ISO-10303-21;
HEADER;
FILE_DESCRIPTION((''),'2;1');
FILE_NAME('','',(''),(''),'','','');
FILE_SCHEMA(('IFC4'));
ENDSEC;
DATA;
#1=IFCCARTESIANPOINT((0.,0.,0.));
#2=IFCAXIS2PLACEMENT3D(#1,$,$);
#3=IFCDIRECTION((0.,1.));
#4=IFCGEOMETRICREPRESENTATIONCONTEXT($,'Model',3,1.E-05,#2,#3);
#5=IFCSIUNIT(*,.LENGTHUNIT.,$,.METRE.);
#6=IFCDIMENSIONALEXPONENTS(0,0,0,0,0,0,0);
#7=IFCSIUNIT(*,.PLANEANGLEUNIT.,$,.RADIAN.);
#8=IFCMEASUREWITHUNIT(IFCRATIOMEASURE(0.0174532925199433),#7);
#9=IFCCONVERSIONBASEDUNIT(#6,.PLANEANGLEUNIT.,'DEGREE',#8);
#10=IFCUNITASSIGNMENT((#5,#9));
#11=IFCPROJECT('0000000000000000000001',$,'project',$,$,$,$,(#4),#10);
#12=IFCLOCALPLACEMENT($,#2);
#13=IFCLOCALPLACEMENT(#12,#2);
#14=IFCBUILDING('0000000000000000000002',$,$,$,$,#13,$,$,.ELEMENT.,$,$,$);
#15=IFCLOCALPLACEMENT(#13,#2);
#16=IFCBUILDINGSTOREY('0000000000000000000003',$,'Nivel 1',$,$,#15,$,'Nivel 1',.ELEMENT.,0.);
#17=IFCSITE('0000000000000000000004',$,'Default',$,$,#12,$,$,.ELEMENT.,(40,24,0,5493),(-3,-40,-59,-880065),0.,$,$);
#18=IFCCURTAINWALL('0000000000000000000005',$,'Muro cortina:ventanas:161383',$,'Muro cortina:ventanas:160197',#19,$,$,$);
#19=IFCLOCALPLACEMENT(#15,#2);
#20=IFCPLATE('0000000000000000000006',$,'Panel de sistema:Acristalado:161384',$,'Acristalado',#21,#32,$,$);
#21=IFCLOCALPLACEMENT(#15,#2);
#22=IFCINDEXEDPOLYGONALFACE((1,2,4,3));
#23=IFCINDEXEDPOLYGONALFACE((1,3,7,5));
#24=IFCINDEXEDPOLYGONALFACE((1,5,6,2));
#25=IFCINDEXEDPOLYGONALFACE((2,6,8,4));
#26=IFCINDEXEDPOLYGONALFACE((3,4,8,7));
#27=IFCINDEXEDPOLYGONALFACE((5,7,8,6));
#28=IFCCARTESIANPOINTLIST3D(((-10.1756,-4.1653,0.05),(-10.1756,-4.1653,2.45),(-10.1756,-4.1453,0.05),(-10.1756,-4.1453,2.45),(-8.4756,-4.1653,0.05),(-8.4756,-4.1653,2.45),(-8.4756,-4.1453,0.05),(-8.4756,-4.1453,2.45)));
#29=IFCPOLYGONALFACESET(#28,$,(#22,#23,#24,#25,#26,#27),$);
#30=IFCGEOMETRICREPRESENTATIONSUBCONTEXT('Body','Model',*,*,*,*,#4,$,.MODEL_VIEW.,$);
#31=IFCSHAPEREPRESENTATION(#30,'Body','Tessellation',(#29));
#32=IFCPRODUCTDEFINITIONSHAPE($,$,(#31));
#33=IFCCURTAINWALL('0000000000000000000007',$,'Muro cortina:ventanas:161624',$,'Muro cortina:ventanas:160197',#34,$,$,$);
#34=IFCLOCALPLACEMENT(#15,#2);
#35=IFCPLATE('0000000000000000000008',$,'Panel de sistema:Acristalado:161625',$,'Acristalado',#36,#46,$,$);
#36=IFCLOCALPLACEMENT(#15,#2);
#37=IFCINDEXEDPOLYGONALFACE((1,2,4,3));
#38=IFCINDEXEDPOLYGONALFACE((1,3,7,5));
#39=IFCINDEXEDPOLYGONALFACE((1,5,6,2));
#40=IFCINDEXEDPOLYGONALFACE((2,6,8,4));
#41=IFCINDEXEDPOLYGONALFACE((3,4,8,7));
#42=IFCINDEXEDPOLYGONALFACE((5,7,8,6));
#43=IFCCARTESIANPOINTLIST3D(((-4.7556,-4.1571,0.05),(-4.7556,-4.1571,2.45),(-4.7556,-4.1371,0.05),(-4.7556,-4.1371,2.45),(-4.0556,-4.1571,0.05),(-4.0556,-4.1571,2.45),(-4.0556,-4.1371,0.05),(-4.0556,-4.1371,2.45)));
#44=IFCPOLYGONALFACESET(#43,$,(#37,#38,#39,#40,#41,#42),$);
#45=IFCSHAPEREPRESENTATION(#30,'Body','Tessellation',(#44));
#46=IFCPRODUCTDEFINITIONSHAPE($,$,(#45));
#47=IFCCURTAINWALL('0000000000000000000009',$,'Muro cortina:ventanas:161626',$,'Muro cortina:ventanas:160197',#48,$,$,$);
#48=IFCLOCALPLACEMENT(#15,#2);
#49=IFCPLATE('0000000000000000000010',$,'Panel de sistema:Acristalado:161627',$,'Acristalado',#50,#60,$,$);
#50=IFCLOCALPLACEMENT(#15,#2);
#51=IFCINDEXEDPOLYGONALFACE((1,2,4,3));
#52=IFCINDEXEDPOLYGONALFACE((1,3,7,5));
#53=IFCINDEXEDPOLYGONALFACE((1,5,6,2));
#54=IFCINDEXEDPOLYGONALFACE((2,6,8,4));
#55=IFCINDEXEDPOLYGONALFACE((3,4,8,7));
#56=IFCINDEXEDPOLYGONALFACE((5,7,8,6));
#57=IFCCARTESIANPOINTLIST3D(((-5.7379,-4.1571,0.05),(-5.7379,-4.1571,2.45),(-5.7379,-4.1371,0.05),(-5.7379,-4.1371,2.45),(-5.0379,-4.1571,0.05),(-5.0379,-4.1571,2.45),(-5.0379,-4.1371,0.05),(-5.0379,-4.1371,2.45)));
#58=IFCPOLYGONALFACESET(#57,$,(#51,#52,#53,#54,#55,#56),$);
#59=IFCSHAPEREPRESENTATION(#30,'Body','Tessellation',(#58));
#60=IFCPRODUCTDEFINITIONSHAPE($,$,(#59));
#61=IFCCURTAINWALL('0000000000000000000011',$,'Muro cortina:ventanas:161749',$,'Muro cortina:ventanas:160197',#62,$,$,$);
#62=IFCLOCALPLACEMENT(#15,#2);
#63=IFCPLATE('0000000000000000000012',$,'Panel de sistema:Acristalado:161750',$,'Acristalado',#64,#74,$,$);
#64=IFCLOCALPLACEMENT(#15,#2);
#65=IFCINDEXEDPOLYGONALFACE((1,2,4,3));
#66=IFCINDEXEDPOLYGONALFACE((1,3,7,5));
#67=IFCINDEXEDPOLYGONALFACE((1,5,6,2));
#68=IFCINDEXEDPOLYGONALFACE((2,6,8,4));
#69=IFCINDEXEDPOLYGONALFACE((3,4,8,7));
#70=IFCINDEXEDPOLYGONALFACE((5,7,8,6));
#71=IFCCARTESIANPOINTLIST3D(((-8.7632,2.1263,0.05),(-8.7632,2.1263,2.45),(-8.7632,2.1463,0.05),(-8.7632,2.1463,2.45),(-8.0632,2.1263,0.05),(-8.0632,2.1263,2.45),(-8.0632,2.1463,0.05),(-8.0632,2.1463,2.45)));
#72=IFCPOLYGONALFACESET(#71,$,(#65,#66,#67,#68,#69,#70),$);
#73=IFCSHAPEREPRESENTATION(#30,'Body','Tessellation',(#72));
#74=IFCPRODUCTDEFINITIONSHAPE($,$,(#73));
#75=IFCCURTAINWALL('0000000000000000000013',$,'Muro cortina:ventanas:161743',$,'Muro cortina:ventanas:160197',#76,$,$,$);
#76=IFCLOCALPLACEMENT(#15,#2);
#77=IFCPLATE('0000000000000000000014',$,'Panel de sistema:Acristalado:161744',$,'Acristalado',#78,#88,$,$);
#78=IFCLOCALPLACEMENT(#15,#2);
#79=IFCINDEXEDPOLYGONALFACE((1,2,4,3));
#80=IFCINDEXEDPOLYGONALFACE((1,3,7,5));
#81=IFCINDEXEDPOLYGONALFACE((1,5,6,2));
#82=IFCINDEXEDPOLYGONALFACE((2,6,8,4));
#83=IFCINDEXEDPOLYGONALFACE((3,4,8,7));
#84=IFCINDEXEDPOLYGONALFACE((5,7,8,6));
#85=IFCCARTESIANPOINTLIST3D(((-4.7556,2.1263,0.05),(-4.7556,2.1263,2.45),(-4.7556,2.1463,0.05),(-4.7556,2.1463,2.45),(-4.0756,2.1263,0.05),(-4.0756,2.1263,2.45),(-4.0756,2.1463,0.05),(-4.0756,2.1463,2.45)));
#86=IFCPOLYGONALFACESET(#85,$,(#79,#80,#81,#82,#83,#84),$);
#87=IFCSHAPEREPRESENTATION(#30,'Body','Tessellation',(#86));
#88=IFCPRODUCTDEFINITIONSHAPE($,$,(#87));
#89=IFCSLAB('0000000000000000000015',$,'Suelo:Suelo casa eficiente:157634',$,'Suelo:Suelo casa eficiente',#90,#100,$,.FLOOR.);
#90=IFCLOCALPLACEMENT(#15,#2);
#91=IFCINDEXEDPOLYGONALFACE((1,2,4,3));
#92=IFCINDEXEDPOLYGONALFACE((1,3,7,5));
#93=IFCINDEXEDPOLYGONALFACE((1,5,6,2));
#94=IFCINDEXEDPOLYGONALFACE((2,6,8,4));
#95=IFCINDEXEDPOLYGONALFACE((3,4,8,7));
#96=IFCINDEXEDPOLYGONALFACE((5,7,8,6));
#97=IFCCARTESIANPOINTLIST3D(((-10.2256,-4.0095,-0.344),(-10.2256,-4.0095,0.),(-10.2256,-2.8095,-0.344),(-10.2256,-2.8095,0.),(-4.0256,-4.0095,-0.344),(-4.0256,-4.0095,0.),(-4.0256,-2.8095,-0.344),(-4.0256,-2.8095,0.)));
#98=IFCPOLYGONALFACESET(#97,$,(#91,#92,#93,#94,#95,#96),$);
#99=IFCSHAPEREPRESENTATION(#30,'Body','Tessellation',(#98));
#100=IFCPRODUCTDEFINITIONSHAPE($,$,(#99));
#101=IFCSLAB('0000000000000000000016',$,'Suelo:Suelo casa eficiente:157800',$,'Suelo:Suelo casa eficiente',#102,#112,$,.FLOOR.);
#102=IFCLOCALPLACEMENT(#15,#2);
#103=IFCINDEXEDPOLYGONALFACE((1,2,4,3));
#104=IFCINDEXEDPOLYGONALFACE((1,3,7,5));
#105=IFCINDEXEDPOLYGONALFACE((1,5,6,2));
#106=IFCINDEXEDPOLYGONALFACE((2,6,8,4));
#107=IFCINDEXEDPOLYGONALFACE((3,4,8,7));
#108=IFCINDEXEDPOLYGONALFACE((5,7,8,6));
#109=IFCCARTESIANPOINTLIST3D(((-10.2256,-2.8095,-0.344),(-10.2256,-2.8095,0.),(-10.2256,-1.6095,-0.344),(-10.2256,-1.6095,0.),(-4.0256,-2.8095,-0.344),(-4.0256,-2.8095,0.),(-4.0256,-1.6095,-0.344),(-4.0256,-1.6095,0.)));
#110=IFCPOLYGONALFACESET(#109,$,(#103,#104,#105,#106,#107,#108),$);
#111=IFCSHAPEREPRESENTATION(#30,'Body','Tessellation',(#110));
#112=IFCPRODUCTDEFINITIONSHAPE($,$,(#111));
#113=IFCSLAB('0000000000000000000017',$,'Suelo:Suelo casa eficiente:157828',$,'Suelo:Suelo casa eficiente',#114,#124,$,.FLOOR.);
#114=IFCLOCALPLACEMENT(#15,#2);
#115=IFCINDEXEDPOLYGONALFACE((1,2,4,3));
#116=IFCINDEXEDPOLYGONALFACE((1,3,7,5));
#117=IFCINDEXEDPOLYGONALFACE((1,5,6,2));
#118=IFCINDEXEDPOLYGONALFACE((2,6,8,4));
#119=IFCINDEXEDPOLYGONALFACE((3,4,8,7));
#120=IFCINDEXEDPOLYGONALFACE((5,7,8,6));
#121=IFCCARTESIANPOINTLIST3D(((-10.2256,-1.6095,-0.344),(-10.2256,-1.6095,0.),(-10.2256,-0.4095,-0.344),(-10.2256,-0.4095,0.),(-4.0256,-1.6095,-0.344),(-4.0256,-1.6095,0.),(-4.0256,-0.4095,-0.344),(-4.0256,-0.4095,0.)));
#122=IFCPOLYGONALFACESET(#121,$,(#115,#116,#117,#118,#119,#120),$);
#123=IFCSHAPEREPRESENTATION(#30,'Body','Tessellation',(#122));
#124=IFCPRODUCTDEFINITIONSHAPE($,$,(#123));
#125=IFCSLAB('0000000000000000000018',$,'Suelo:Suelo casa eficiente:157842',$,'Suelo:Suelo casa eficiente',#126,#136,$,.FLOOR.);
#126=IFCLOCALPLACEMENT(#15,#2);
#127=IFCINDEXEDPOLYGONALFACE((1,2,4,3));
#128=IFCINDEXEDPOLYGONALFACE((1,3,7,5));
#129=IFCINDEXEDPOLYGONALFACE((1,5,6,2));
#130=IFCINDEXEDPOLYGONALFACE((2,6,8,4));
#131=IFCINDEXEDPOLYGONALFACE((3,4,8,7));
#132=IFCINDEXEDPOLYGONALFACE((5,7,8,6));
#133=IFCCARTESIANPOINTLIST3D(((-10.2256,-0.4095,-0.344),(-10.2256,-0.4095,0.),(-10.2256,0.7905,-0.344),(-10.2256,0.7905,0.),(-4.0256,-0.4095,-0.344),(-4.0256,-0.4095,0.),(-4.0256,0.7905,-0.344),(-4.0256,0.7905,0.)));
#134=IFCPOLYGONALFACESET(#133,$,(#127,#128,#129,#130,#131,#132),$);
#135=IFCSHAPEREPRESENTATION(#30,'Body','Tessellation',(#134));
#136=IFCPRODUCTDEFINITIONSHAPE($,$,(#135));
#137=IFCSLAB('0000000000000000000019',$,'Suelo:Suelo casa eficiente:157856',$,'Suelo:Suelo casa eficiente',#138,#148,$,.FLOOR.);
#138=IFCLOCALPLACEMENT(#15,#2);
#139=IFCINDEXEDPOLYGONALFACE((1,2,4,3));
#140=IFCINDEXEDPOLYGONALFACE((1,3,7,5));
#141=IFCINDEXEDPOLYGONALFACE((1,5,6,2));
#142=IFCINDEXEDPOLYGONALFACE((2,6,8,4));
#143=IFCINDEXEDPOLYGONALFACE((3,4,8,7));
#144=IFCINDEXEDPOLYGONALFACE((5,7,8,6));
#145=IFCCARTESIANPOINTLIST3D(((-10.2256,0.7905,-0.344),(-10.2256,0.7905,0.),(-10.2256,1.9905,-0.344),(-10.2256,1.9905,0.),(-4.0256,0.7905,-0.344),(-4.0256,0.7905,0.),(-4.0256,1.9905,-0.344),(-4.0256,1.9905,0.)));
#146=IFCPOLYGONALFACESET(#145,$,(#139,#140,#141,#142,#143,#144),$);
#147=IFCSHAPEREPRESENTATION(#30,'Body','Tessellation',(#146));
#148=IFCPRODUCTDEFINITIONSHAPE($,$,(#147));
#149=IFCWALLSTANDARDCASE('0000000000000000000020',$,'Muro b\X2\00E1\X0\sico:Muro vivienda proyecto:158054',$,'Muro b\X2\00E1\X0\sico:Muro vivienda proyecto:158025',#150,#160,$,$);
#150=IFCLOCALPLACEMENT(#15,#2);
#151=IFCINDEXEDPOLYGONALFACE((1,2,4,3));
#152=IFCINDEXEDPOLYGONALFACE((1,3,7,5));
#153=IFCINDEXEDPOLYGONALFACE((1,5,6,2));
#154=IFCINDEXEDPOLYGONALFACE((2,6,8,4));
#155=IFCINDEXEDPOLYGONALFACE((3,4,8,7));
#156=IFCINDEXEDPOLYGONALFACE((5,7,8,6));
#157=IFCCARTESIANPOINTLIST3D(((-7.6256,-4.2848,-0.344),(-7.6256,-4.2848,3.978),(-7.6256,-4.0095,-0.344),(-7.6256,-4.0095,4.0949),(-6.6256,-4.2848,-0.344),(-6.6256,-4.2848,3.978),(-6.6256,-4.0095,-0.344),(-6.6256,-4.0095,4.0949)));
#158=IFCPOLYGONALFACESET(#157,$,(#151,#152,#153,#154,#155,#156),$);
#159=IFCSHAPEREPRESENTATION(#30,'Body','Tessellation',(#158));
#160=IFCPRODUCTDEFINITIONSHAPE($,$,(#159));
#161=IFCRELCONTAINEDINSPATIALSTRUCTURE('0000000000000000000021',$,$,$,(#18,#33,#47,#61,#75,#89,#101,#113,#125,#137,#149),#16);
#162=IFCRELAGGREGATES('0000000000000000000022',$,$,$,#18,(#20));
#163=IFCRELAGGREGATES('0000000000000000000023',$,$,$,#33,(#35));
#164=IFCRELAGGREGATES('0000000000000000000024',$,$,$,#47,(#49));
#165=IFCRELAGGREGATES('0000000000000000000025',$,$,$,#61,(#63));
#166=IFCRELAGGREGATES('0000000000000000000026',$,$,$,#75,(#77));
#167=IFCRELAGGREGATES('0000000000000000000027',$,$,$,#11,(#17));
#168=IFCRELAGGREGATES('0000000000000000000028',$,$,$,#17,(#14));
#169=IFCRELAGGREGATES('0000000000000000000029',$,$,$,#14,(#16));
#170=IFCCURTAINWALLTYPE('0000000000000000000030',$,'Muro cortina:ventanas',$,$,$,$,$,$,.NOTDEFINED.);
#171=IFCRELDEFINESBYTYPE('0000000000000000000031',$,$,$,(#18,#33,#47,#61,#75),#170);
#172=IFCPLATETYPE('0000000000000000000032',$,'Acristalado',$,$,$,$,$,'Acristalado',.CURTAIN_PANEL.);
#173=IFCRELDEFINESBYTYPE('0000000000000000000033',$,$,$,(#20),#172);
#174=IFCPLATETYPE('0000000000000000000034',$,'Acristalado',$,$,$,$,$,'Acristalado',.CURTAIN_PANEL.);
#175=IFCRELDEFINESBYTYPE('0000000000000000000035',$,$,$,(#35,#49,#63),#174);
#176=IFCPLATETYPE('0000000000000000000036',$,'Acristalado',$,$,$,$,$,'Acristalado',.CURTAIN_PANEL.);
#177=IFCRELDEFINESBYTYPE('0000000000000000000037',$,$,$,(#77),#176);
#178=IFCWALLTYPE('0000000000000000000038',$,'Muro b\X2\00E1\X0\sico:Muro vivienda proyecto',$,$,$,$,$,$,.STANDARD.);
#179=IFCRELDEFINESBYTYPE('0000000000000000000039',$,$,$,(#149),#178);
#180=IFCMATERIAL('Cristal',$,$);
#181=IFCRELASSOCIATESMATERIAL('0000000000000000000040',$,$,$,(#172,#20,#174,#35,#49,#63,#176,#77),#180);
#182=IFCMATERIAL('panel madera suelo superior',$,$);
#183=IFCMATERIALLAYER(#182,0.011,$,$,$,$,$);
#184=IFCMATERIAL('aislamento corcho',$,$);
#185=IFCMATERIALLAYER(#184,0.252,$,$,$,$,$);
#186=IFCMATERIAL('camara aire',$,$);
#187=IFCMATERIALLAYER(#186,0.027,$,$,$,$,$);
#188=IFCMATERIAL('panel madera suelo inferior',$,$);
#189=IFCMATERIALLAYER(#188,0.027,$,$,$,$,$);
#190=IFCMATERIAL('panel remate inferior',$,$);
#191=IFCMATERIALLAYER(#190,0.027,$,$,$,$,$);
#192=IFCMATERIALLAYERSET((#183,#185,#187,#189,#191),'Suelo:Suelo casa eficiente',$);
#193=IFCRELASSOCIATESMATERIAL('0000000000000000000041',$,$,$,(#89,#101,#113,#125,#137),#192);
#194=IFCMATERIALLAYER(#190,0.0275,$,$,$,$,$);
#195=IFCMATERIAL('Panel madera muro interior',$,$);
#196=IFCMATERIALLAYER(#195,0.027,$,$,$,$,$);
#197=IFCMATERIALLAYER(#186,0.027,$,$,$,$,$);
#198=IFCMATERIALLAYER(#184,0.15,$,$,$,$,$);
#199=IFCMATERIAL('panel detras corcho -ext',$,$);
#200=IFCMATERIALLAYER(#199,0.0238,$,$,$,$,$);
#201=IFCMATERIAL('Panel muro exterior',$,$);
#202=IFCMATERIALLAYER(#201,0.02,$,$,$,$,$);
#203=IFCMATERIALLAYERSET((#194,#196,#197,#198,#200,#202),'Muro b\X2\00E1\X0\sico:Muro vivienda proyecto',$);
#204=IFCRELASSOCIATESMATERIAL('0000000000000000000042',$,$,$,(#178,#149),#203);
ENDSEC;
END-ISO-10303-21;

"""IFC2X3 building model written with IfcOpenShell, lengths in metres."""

from ifc_helpers import new_model, entity, si_unit, converted_unit, direction, frame, frame_2d, origin, origin_2d_with_axis, place, context, subcontext, project, spatial, polyline, rectangle, extrude, clip, bounded_halfspace, source, transform, mapped, material, layer, layer_set, layer_usage, type_object, type_shapes, element, aggregate, save


model = new_model("IFC2X3")

# Units and contexts
model_context = context("Model", 3, precision=1e-05, world=origin(), true_north=direction((0.0, 1.0)))
body_context = subcontext(model_context, "Body", "Model", "MODEL_VIEW")
ifc_project = project(units=[si_unit("LENGTHUNIT", "METRE"), converted_unit("PLANEANGLEUNIT", "DEGREE", entity("IfcRatioMeasure", 0.0174532925199433), si_unit("PLANEANGLEUNIT", "RADIAN"), dimensions=[0, 0, 0, 0, 0, 0, 0])], contexts=[model_context])

# Site, building, storey
site_placement = place(None, origin())
site = spatial("IfcSite", under=ifc_project, at=site_placement, Name="Default", CompositionType="ELEMENT", RefLatitude=(40, 24, 0, 5493), RefLongitude=(-3, -40, -59, -880065), RefElevation=0.0)
building_placement = place(site_placement, origin())
building = spatial("IfcBuilding", under=site, at=building_placement, CompositionType="ELEMENT")
storey_placement = place(building_placement, origin())
storey = spatial("IfcBuildingStorey", under=building, at=storey_placement, Name="Nivel 1", LongName="Nivel 1", CompositionType="ELEMENT", Elevation=0.0)

# Curtain walls, plates
curtain_wall_type = type_object("IfcCurtainWallType", Name="Muro cortina:ventanas", PredefinedType="NOTDEFINED")
curtain_wall_1_placement = place(storey_placement, origin())
curtain_wall_1 = element("IfcCurtainWall", 1, at=curtain_wall_1_placement, inside=storey, type_object=curtain_wall_type, Name="Muro cortina:ventanas:161383", ObjectType="Muro cortina:ventanas:160197")
ifc_material_1 = material(Name="Cristal")
plate_type_1 = type_object("IfcPlateType", Name="Acristalado", ElementType="Acristalado", PredefinedType="CURTAIN_PANEL", material=ifc_material_1)
shared_shape_1 = source(origin(), body_context, "Body", "SweptSolid", [
    extrude(rectangle(XDim=0.02, YDim=1.7, at=origin_2d_with_axis()), frame((0.0, 0.0, 0.0), z_axis=(0.0, 0.0, 1.0), x_axis=(0.0, 1.0, 0.0)), (0.0, 0.0, 1.0), 2.4),
])
type_shapes(plate_type_1, [shared_shape_1])
plate_1_placement = place(curtain_wall_1_placement, frame((-9.3256, -4.1553, 0.05)))
plate_1 = element("IfcPlate", 2, at=plate_1_placement, type_object=plate_type_1, material=ifc_material_1, Name="Panel de sistema:Acristalado:161384", ObjectType="Acristalado", context=body_context, shape_type="MappedRepresentation", body=[
    mapped(shared_shape_1, transform((0.0, 0.0, 0.0), scale=1.0)),
])
aggregate(curtain_wall_1, [plate_1])
curtain_wall_2_placement = place(storey_placement, origin())
curtain_wall_2 = element("IfcCurtainWall", 3, at=curtain_wall_2_placement, inside=storey, type_object=curtain_wall_type, Name="Muro cortina:ventanas:161624", ObjectType="Muro cortina:ventanas:160197")
plate_type_2 = type_object("IfcPlateType", Name="Acristalado", ElementType="Acristalado", PredefinedType="CURTAIN_PANEL", material=ifc_material_1)
shared_shape_2 = source(origin(), body_context, "Body", "SweptSolid", [
    extrude(rectangle(XDim=0.02, YDim=0.7, at=origin_2d_with_axis()), frame((0.0, 0.0, 0.0), z_axis=(0.0, 0.0, 1.0), x_axis=(0.0, 1.0, 0.0)), (0.0, 0.0, 1.0), 2.4),
])
type_shapes(plate_type_2, [shared_shape_2])
plate_2_placement = place(curtain_wall_2_placement, frame((-4.4056, -4.1471, 0.05), z_axis=(0.0, 0.0, 1.0), x_axis=(-1.0, 0.0, 0.0)))
plate_2 = element("IfcPlate", 4, at=plate_2_placement, type_object=plate_type_2, material=ifc_material_1, Name="Panel de sistema:Acristalado:161625", ObjectType="Acristalado", context=body_context, shape_type="MappedRepresentation", body=[
    mapped(shared_shape_2, transform((0.0, 0.0, 0.0), scale=1.0)),
])
aggregate(curtain_wall_2, [plate_2])
curtain_wall_3_placement = place(storey_placement, origin())
curtain_wall_3 = element("IfcCurtainWall", 5, at=curtain_wall_3_placement, inside=storey, type_object=curtain_wall_type, Name="Muro cortina:ventanas:161626", ObjectType="Muro cortina:ventanas:160197")
plate_3_placement = place(curtain_wall_3_placement, frame((-5.3879, -4.1471, 0.05), z_axis=(0.0, 0.0, 1.0), x_axis=(-1.0, 0.0, 0.0)))
plate_3 = element("IfcPlate", 6, at=plate_3_placement, type_object=plate_type_2, material=ifc_material_1, Name="Panel de sistema:Acristalado:161627", ObjectType="Acristalado", context=body_context, shape_type="MappedRepresentation", body=[
    mapped(shared_shape_2, transform((0.0, 0.0, 0.0), scale=1.0)),
])
aggregate(curtain_wall_3, [plate_3])
curtain_wall_4_placement = place(storey_placement, origin())
curtain_wall_4 = element("IfcCurtainWall", 7, at=curtain_wall_4_placement, inside=storey, type_object=curtain_wall_type, Name="Muro cortina:ventanas:161749", ObjectType="Muro cortina:ventanas:160197")
plate_4_placement = place(curtain_wall_4_placement, frame((-8.4132, 2.1363, 0.05), z_axis=(0.0, 0.0, 1.0), x_axis=(-1.0, 0.0, 0.0)))
plate_4 = element("IfcPlate", 8, at=plate_4_placement, type_object=plate_type_2, material=ifc_material_1, Name="Panel de sistema:Acristalado:161750", ObjectType="Acristalado", context=body_context, shape_type="MappedRepresentation", body=[
    mapped(shared_shape_2, transform((0.0, 0.0, 0.0), scale=1.0)),
])
aggregate(curtain_wall_4, [plate_4])
curtain_wall_5_placement = place(storey_placement, origin())
curtain_wall_5 = element("IfcCurtainWall", 9, at=curtain_wall_5_placement, inside=storey, type_object=curtain_wall_type, Name="Muro cortina:ventanas:161743", ObjectType="Muro cortina:ventanas:160197")
plate_type_3 = type_object("IfcPlateType", Name="Acristalado", ElementType="Acristalado", PredefinedType="CURTAIN_PANEL", material=ifc_material_1)
shared_shape_3 = source(origin(), body_context, "Body", "SweptSolid", [
    extrude(rectangle(XDim=0.02, YDim=0.68, at=origin_2d_with_axis()), frame((0.0, 0.0, 0.0), z_axis=(0.0, 0.0, 1.0), x_axis=(0.0, 1.0, 0.0)), (0.0, 0.0, 1.0), 2.4),
])
type_shapes(plate_type_3, [shared_shape_3])
plate_5_placement = place(curtain_wall_5_placement, frame((-4.4156, 2.1363, 0.05), z_axis=(0.0, 0.0, 1.0), x_axis=(-1.0, 0.0, 0.0)))
plate_5 = element("IfcPlate", 10, at=plate_5_placement, type_object=plate_type_3, material=ifc_material_1, Name="Panel de sistema:Acristalado:161744", ObjectType="Acristalado", context=body_context, shape_type="MappedRepresentation", body=[
    mapped(shared_shape_3, transform((0.0, 0.0, 0.0), scale=1.0)),
])
aggregate(curtain_wall_5, [plate_5])

# Slabs
ifc_material_2 = material(Name="panel madera suelo superior")
ifc_layer_1 = layer(ifc_material_2, 0.011)
ifc_material_3 = material(Name="aislamento corcho")
ifc_layer_2 = layer(ifc_material_3, 0.252)
ifc_material_4 = material(Name="camara aire")
ifc_layer_3 = layer(ifc_material_4, 0.027)
ifc_material_5 = material(Name="panel madera suelo inferior")
ifc_layer_4 = layer(ifc_material_5, 0.027)
ifc_material_6 = material(Name="panel remate inferior")
ifc_layer_5 = layer(ifc_material_6, 0.027)
ifc_layer_set_1 = layer_set([ifc_layer_1, ifc_layer_2, ifc_layer_3, ifc_layer_4, ifc_layer_5], Name="Suelo:Suelo casa eficiente")
ifc_layer_usage_1 = layer_usage(ifc_layer_set_1, "AXIS3", "POSITIVE", 0.0)
slab_1_placement = place(storey_placement, origin())
element("IfcSlab", 11, at=slab_1_placement, inside=storey, material=ifc_layer_usage_1, Name="Suelo:Suelo casa eficiente:157634", ObjectType="Suelo:Suelo casa eficiente", PredefinedType="FLOOR", context=body_context, shape_type="SweptSolid", body=[
    extrude(rectangle(XDim=1.2, YDim=6.2, at=origin_2d_with_axis()), frame((-7.1256, -3.4095, 0.0), z_axis=(0.0, 0.0, -1.0), x_axis=(0.0, 1.0, 0.0)), (0.0, 0.0, 1.0), 0.344),
])
ifc_layer_usage_2 = layer_usage(ifc_layer_set_1, "AXIS3", "POSITIVE", 0.0)
slab_2_placement = place(storey_placement, origin())
element("IfcSlab", 12, at=slab_2_placement, inside=storey, material=ifc_layer_usage_2, Name="Suelo:Suelo casa eficiente:157800", ObjectType="Suelo:Suelo casa eficiente", PredefinedType="FLOOR", context=body_context, shape_type="SweptSolid", body=[
    extrude(rectangle(XDim=1.2, YDim=6.2, at=frame_2d((0.0, 0.0), x_axis=(1.0, 0.0))), frame((-7.1256, -2.2095, 0.0), z_axis=(0.0, 0.0, -1.0), x_axis=(0.0, 1.0, 0.0)), (0.0, 0.0, 1.0), 0.344),
])
ifc_layer_usage_3 = layer_usage(ifc_layer_set_1, "AXIS3", "POSITIVE", 0.0)
slab_3_placement = place(storey_placement, origin())
element("IfcSlab", 13, at=slab_3_placement, inside=storey, material=ifc_layer_usage_3, Name="Suelo:Suelo casa eficiente:157828", ObjectType="Suelo:Suelo casa eficiente", PredefinedType="FLOOR", context=body_context, shape_type="SweptSolid", body=[
    extrude(rectangle(XDim=1.2, YDim=6.2, at=frame_2d((0.0, 0.0), x_axis=(1.0, 0.0))), frame((-7.1256, -1.0095, 0.0), z_axis=(0.0, 0.0, -1.0), x_axis=(0.0, 1.0, 0.0)), (0.0, 0.0, 1.0), 0.344),
])
ifc_layer_usage_4 = layer_usage(ifc_layer_set_1, "AXIS3", "POSITIVE", 0.0)
slab_4_placement = place(storey_placement, origin())
element("IfcSlab", 14, at=slab_4_placement, inside=storey, material=ifc_layer_usage_4, Name="Suelo:Suelo casa eficiente:157842", ObjectType="Suelo:Suelo casa eficiente", PredefinedType="FLOOR", context=body_context, shape_type="SweptSolid", body=[
    extrude(rectangle(XDim=1.2, YDim=6.2, at=frame_2d((0.0, 0.0), x_axis=(1.0, 0.0))), frame((-7.1256, 0.1905, 0.0), z_axis=(0.0, 0.0, -1.0), x_axis=(0.0, 1.0, 0.0)), (0.0, 0.0, 1.0), 0.344),
])
ifc_layer_usage_5 = layer_usage(ifc_layer_set_1, "AXIS3", "POSITIVE", 0.0)
slab_5_placement = place(storey_placement, origin())
element("IfcSlab", 15, at=slab_5_placement, inside=storey, material=ifc_layer_usage_5, Name="Suelo:Suelo casa eficiente:157856", ObjectType="Suelo:Suelo casa eficiente", PredefinedType="FLOOR", context=body_context, shape_type="SweptSolid", body=[
    extrude(rectangle(XDim=1.2, YDim=6.2, at=origin_2d_with_axis()), frame((-7.1256, 1.3905, 0.0), z_axis=(0.0, 0.0, -1.0), x_axis=(0.0, 1.0, 0.0)), (0.0, 0.0, 1.0), 0.344),
])

# Wall
ifc_layer_6 = layer(ifc_material_6, 0.0275)
ifc_material_7 = material(Name="Panel madera muro interior")
ifc_layer_7 = layer(ifc_material_7, 0.027)
ifc_layer_8 = layer(ifc_material_4, 0.027)
ifc_layer_9 = layer(ifc_material_3, 0.15)
ifc_material_8 = material(Name="panel detras corcho -ext")
ifc_layer_10 = layer(ifc_material_8, 0.0238)
ifc_material_9 = material(Name="Panel muro exterior")
ifc_layer_11 = layer(ifc_material_9, 0.02)
ifc_layer_set_2 = layer_set([ifc_layer_6, ifc_layer_7, ifc_layer_8, ifc_layer_9, ifc_layer_10, ifc_layer_11], Name="Muro básico:Muro vivienda proyecto")
ifc_layer_usage_6 = layer_usage(ifc_layer_set_2, "AXIS2", "NEGATIVE", 0.1376)
wall_type = type_object("IfcWallType", Name="Muro básico:Muro vivienda proyecto", PredefinedType="STANDARD", material=ifc_layer_set_2)
wall_1_placement = place(storey_placement, frame((-6.6256, -4.1471, -0.344), z_axis=(0.0, 0.0, 1.0), x_axis=(-1.0, 0.0, 0.0)))
element("IfcWallStandardCase", 16, at=wall_1_placement, inside=storey, type_object=wall_type, material=ifc_layer_usage_6, Name="Muro básico:Muro vivienda proyecto:158054", ObjectType="Muro básico:Muro vivienda proyecto:158025", context=body_context, shape_type="Clipping", body=[
    clip(extrude(rectangle(XDim=1.0, YDim=0.2753, at=frame_2d((0.5, 0.0), x_axis=(-1.0, 0.0))), origin(), (0.0, 0.0, 1.0), 4.4389), bounded_halfspace(frame((0.0, -0.1376, 4.4389), z_axis=(0.0, 0.390731, 0.920505), x_axis=(-1.0, 0.0, 0.0)), False, frame((0.0, -0.1376, 4.4389)), polyline([(0.0, 0.0), (1.0, 0.0), (1.0, 0.2753), (0.0, 0.2753), (0.0, 0.0)]))),
])

save(model, "model.ifc")
